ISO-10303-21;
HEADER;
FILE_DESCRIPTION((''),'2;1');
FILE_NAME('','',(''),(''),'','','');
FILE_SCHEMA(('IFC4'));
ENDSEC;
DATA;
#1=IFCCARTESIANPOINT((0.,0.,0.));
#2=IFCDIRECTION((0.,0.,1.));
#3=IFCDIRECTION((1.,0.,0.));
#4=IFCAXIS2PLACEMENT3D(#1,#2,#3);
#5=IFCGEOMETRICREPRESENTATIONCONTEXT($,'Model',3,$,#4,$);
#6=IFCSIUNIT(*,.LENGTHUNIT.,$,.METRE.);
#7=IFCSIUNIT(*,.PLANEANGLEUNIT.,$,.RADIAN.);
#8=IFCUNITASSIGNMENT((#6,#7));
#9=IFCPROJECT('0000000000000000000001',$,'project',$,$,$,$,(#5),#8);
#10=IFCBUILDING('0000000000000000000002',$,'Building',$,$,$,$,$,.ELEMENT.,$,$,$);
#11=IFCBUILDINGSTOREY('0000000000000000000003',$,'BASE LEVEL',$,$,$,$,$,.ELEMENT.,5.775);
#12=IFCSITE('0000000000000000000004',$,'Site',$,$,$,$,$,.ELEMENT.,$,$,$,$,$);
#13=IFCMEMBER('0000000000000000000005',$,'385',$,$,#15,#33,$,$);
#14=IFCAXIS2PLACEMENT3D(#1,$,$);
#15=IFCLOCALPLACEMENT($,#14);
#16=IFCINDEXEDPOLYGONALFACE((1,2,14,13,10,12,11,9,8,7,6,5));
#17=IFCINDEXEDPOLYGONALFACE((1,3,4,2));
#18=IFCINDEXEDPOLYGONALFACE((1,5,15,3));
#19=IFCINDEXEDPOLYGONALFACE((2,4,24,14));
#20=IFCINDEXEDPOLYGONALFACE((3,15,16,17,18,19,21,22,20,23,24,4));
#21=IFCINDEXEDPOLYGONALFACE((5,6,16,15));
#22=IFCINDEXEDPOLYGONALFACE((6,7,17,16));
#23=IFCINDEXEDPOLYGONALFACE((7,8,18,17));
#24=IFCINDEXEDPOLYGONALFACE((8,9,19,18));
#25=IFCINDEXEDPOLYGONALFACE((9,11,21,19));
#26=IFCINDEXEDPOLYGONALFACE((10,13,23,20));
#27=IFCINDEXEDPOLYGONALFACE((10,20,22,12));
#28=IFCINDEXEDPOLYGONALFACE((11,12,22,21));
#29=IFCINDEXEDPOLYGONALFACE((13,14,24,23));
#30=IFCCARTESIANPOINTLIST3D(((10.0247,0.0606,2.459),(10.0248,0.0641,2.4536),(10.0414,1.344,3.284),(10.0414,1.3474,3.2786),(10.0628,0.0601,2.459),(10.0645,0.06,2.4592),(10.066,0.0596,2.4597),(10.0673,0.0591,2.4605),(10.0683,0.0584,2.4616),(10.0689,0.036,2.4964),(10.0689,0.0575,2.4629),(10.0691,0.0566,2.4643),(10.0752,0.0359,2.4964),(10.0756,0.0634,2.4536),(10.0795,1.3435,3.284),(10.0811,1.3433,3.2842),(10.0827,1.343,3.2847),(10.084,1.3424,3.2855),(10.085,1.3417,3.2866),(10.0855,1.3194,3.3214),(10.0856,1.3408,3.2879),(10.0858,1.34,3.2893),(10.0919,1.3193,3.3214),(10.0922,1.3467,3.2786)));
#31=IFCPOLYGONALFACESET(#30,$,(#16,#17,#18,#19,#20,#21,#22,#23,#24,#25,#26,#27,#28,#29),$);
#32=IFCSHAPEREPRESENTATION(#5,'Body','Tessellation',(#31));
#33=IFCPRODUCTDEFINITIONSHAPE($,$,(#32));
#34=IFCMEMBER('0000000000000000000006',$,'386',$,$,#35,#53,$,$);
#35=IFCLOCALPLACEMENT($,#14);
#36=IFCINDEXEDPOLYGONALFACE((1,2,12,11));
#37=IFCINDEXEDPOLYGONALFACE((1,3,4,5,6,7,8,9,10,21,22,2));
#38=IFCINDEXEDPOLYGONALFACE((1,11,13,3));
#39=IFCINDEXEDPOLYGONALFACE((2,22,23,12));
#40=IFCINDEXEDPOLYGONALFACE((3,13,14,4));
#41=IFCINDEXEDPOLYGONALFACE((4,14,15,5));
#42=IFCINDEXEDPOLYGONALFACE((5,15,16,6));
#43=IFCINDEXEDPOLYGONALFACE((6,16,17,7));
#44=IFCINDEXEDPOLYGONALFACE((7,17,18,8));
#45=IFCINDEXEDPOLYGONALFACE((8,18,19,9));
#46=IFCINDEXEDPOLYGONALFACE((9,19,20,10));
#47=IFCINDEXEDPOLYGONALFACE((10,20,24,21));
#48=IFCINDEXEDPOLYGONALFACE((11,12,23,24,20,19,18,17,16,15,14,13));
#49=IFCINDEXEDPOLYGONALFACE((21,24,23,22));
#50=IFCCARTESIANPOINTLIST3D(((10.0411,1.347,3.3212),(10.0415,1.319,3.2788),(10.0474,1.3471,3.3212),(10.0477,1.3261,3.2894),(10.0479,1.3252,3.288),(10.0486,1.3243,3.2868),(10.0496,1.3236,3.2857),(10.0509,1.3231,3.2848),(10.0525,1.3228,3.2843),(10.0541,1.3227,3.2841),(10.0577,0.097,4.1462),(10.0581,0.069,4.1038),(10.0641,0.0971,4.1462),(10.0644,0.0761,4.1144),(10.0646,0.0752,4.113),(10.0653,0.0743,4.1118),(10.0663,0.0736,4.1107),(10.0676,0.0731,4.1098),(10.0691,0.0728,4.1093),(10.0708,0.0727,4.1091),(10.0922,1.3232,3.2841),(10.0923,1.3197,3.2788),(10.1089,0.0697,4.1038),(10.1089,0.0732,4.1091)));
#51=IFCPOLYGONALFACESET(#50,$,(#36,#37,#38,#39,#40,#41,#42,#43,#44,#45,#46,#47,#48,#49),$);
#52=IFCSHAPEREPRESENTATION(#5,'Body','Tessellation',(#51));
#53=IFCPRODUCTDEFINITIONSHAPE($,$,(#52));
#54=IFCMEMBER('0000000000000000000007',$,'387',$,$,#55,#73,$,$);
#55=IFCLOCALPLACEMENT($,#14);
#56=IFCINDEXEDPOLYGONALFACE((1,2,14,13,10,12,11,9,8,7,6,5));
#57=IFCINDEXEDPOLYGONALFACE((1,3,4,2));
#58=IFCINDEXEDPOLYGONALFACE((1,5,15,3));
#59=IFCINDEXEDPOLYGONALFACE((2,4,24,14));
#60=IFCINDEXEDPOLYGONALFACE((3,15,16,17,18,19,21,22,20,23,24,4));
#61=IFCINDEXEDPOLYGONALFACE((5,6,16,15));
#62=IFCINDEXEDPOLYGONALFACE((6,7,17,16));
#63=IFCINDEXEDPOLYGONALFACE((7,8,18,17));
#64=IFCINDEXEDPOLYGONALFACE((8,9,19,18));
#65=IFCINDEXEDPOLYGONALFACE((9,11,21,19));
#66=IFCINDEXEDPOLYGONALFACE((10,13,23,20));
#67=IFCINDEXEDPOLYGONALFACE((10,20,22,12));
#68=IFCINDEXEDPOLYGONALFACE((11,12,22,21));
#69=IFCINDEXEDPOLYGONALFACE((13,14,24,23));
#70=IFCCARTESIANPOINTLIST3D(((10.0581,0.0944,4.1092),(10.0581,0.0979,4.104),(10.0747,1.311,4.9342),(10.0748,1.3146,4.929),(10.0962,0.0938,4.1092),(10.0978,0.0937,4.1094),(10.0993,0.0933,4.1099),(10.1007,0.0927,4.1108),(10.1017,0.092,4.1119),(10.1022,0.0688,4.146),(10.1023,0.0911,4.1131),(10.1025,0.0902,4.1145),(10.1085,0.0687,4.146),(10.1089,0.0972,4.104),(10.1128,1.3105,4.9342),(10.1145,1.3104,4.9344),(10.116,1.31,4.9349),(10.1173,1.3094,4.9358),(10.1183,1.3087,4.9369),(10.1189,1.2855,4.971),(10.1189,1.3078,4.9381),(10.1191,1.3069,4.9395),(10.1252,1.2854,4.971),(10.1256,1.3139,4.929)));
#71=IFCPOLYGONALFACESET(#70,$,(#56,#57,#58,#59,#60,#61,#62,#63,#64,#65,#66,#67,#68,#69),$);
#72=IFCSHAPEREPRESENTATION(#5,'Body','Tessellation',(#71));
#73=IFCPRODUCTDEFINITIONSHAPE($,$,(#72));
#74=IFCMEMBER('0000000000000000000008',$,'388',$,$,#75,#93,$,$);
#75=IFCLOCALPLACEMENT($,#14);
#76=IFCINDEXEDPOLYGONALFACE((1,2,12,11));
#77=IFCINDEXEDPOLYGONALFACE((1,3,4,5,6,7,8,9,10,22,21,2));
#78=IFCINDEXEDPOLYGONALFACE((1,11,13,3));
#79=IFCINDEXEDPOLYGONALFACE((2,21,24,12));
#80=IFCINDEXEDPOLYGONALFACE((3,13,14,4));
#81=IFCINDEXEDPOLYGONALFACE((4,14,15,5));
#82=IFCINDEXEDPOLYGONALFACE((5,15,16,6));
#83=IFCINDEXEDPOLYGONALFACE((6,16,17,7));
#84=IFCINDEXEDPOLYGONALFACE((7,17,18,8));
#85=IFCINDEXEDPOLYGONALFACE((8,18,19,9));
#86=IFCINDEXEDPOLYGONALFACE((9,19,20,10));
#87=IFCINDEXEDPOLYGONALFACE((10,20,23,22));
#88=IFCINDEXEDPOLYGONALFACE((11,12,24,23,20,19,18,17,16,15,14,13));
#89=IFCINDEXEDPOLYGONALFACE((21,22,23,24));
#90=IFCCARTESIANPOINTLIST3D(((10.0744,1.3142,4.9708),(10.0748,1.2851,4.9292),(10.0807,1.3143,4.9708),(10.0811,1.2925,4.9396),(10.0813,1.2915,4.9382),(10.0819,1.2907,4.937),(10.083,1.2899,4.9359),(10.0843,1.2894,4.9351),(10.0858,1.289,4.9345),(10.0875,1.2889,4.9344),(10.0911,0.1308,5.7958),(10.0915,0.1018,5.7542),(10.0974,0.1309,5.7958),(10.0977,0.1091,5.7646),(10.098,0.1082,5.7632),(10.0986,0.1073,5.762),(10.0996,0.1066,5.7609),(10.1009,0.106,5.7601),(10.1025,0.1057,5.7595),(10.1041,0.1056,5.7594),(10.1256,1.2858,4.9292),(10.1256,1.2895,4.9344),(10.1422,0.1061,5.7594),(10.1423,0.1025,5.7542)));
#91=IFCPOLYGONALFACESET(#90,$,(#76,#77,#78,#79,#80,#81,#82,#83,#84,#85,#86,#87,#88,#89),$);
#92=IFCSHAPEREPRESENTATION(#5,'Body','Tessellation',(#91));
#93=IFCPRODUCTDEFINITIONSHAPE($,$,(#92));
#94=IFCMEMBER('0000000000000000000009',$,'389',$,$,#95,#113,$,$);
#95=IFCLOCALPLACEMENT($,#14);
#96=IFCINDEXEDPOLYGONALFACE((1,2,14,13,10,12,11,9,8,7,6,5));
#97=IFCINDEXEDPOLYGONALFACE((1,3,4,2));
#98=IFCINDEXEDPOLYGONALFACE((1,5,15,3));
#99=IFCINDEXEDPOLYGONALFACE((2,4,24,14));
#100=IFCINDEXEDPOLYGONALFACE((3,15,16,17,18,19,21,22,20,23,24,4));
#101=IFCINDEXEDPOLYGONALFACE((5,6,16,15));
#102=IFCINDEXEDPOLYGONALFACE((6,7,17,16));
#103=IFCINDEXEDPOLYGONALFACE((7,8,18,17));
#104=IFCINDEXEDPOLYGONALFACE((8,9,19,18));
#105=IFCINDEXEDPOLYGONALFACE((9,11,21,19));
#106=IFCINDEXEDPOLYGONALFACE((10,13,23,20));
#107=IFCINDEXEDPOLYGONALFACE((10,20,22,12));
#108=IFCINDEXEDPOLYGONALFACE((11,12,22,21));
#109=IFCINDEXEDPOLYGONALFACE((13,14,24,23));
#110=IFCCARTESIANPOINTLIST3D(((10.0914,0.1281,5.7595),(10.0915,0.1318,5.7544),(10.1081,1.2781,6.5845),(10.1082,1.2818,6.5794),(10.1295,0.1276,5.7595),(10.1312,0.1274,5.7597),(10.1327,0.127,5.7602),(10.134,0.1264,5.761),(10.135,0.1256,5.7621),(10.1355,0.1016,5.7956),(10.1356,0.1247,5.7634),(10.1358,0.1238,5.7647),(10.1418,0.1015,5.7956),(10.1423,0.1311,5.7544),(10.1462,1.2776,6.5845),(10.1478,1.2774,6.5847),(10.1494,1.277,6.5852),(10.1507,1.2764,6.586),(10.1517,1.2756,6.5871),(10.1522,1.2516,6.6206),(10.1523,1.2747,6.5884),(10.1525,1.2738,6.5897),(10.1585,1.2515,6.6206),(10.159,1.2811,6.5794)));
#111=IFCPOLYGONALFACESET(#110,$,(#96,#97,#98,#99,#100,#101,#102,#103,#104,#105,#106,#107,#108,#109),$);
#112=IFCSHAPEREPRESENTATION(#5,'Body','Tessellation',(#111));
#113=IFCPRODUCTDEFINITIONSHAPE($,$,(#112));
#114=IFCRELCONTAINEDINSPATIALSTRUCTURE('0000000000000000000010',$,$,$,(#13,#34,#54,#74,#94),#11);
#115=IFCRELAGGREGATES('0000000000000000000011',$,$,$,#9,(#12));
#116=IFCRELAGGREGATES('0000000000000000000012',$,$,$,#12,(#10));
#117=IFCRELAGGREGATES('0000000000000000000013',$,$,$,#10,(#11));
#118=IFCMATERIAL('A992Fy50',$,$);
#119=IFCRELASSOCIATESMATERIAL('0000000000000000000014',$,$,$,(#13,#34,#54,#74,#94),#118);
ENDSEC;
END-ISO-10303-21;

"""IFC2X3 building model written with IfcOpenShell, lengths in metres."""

from ifc_helpers import new_model, si_unit, frame, origin_with_axes, origin_2d_with_axis, place, context, project, spatial, l_section, extrude, material, element, save


model = new_model("IFC2X3")

# Units and contexts
model_context = context("Model", 3, world=origin_with_axes())
ifc_project = project(units=[si_unit("LENGTHUNIT", "METRE"), si_unit("PLANEANGLEUNIT", "RADIAN")], contexts=[model_context])

# Site, building, storey
site = spatial("IfcSite", under=ifc_project, Name="Site", CompositionType="ELEMENT")
building = spatial("IfcBuilding", under=site, Name="Building", CompositionType="ELEMENT")
storey = spatial("IfcBuildingStorey", under=building, Name="BASE LEVEL", CompositionType="ELEMENT", Elevation=5.775)

# Shared definitions
ifc_material = material(Name="A992Fy50")

# Members
member_1_placement = place(None, frame((10.05, 0.05, 2.475), z_axis=(0.010924, 0.841128, 0.540725), x_axis=(-0.999924, 0.012345, 0.0)))
element("IfcMember", 1, at=member_1_placement, inside=storey, material=ifc_material, Name="385", context=model_context, shape_type="SweptSolid", body=[
    extrude(l_section(Depth=0.0508, Width=0.0508, Thickness=0.0063, FilletRadius=0.0063, at=origin_2d_with_axis()), origin_with_axes(), (0.0, 0.0, 1.0), 1.5257),
])
member_2_placement = place(None, frame((10.0667, 1.3333, 3.3), z_axis=(0.011127, -0.834558, 0.550808), x_axis=(0.999911, 0.013332, 0.0)))
element("IfcMember", 2, at=member_2_placement, inside=storey, material=ifc_material, Name="386", context=model_context, shape_type="SweptSolid", body=[
    extrude(l_section(Depth=0.0508, Width=0.0508, Thickness=0.0063, FilletRadius=0.0063, at=origin_2d_with_axis()), origin_with_axes(), (0.0, 0.0, 1.0), 1.4978),
])
member_3_placement = place(None, frame((10.0833, 0.0833, 4.125), z_axis=(0.011337, 0.827611, 0.561188), x_axis=(-0.999906, 0.013697, 0.0)))
element("IfcMember", 3, at=member_3_placement, inside=storey, material=ifc_material, Name="387", context=model_context, shape_type="SweptSolid", body=[
    extrude(l_section(Depth=0.0508, Width=0.0508, Thickness=0.0063, FilletRadius=0.0063, at=origin_2d_with_axis()), origin_with_axes(), (0.0, 0.0, 1.0), 1.4701),
])
member_4_placement = place(None, frame((10.1, 1.3, 4.95), z_axis=(0.011553, -0.820261, 0.571872), x_axis=(0.999889, 0.014924, 0.0)))
element("IfcMember", 4, at=member_4_placement, inside=storey, material=ifc_material, Name="388", context=model_context, shape_type="SweptSolid", body=[
    extrude(l_section(Depth=0.0508, Width=0.0508, Thickness=0.0063, FilletRadius=0.0063, at=origin_2d_with_axis()), origin_with_axes(), (0.0, 0.0, 1.0), 1.4426),
])
member_5_placement = place(None, frame((10.1167, 0.1167, 5.775), z_axis=(0.011775, 0.812482, 0.582867), x_axis=(-0.999882, 0.015383, 0.0)))
element("IfcMember", 5, at=member_5_placement, inside=storey, material=ifc_material, Name="389", context=model_context, shape_type="SweptSolid", body=[
    extrude(l_section(Depth=0.0508, Width=0.0508, Thickness=0.0063, FilletRadius=0.0063, at=origin_2d_with_axis()), origin_with_axes(), (0.0, 0.0, 1.0), 1.4154),
])

save(model, "model.ifc")
